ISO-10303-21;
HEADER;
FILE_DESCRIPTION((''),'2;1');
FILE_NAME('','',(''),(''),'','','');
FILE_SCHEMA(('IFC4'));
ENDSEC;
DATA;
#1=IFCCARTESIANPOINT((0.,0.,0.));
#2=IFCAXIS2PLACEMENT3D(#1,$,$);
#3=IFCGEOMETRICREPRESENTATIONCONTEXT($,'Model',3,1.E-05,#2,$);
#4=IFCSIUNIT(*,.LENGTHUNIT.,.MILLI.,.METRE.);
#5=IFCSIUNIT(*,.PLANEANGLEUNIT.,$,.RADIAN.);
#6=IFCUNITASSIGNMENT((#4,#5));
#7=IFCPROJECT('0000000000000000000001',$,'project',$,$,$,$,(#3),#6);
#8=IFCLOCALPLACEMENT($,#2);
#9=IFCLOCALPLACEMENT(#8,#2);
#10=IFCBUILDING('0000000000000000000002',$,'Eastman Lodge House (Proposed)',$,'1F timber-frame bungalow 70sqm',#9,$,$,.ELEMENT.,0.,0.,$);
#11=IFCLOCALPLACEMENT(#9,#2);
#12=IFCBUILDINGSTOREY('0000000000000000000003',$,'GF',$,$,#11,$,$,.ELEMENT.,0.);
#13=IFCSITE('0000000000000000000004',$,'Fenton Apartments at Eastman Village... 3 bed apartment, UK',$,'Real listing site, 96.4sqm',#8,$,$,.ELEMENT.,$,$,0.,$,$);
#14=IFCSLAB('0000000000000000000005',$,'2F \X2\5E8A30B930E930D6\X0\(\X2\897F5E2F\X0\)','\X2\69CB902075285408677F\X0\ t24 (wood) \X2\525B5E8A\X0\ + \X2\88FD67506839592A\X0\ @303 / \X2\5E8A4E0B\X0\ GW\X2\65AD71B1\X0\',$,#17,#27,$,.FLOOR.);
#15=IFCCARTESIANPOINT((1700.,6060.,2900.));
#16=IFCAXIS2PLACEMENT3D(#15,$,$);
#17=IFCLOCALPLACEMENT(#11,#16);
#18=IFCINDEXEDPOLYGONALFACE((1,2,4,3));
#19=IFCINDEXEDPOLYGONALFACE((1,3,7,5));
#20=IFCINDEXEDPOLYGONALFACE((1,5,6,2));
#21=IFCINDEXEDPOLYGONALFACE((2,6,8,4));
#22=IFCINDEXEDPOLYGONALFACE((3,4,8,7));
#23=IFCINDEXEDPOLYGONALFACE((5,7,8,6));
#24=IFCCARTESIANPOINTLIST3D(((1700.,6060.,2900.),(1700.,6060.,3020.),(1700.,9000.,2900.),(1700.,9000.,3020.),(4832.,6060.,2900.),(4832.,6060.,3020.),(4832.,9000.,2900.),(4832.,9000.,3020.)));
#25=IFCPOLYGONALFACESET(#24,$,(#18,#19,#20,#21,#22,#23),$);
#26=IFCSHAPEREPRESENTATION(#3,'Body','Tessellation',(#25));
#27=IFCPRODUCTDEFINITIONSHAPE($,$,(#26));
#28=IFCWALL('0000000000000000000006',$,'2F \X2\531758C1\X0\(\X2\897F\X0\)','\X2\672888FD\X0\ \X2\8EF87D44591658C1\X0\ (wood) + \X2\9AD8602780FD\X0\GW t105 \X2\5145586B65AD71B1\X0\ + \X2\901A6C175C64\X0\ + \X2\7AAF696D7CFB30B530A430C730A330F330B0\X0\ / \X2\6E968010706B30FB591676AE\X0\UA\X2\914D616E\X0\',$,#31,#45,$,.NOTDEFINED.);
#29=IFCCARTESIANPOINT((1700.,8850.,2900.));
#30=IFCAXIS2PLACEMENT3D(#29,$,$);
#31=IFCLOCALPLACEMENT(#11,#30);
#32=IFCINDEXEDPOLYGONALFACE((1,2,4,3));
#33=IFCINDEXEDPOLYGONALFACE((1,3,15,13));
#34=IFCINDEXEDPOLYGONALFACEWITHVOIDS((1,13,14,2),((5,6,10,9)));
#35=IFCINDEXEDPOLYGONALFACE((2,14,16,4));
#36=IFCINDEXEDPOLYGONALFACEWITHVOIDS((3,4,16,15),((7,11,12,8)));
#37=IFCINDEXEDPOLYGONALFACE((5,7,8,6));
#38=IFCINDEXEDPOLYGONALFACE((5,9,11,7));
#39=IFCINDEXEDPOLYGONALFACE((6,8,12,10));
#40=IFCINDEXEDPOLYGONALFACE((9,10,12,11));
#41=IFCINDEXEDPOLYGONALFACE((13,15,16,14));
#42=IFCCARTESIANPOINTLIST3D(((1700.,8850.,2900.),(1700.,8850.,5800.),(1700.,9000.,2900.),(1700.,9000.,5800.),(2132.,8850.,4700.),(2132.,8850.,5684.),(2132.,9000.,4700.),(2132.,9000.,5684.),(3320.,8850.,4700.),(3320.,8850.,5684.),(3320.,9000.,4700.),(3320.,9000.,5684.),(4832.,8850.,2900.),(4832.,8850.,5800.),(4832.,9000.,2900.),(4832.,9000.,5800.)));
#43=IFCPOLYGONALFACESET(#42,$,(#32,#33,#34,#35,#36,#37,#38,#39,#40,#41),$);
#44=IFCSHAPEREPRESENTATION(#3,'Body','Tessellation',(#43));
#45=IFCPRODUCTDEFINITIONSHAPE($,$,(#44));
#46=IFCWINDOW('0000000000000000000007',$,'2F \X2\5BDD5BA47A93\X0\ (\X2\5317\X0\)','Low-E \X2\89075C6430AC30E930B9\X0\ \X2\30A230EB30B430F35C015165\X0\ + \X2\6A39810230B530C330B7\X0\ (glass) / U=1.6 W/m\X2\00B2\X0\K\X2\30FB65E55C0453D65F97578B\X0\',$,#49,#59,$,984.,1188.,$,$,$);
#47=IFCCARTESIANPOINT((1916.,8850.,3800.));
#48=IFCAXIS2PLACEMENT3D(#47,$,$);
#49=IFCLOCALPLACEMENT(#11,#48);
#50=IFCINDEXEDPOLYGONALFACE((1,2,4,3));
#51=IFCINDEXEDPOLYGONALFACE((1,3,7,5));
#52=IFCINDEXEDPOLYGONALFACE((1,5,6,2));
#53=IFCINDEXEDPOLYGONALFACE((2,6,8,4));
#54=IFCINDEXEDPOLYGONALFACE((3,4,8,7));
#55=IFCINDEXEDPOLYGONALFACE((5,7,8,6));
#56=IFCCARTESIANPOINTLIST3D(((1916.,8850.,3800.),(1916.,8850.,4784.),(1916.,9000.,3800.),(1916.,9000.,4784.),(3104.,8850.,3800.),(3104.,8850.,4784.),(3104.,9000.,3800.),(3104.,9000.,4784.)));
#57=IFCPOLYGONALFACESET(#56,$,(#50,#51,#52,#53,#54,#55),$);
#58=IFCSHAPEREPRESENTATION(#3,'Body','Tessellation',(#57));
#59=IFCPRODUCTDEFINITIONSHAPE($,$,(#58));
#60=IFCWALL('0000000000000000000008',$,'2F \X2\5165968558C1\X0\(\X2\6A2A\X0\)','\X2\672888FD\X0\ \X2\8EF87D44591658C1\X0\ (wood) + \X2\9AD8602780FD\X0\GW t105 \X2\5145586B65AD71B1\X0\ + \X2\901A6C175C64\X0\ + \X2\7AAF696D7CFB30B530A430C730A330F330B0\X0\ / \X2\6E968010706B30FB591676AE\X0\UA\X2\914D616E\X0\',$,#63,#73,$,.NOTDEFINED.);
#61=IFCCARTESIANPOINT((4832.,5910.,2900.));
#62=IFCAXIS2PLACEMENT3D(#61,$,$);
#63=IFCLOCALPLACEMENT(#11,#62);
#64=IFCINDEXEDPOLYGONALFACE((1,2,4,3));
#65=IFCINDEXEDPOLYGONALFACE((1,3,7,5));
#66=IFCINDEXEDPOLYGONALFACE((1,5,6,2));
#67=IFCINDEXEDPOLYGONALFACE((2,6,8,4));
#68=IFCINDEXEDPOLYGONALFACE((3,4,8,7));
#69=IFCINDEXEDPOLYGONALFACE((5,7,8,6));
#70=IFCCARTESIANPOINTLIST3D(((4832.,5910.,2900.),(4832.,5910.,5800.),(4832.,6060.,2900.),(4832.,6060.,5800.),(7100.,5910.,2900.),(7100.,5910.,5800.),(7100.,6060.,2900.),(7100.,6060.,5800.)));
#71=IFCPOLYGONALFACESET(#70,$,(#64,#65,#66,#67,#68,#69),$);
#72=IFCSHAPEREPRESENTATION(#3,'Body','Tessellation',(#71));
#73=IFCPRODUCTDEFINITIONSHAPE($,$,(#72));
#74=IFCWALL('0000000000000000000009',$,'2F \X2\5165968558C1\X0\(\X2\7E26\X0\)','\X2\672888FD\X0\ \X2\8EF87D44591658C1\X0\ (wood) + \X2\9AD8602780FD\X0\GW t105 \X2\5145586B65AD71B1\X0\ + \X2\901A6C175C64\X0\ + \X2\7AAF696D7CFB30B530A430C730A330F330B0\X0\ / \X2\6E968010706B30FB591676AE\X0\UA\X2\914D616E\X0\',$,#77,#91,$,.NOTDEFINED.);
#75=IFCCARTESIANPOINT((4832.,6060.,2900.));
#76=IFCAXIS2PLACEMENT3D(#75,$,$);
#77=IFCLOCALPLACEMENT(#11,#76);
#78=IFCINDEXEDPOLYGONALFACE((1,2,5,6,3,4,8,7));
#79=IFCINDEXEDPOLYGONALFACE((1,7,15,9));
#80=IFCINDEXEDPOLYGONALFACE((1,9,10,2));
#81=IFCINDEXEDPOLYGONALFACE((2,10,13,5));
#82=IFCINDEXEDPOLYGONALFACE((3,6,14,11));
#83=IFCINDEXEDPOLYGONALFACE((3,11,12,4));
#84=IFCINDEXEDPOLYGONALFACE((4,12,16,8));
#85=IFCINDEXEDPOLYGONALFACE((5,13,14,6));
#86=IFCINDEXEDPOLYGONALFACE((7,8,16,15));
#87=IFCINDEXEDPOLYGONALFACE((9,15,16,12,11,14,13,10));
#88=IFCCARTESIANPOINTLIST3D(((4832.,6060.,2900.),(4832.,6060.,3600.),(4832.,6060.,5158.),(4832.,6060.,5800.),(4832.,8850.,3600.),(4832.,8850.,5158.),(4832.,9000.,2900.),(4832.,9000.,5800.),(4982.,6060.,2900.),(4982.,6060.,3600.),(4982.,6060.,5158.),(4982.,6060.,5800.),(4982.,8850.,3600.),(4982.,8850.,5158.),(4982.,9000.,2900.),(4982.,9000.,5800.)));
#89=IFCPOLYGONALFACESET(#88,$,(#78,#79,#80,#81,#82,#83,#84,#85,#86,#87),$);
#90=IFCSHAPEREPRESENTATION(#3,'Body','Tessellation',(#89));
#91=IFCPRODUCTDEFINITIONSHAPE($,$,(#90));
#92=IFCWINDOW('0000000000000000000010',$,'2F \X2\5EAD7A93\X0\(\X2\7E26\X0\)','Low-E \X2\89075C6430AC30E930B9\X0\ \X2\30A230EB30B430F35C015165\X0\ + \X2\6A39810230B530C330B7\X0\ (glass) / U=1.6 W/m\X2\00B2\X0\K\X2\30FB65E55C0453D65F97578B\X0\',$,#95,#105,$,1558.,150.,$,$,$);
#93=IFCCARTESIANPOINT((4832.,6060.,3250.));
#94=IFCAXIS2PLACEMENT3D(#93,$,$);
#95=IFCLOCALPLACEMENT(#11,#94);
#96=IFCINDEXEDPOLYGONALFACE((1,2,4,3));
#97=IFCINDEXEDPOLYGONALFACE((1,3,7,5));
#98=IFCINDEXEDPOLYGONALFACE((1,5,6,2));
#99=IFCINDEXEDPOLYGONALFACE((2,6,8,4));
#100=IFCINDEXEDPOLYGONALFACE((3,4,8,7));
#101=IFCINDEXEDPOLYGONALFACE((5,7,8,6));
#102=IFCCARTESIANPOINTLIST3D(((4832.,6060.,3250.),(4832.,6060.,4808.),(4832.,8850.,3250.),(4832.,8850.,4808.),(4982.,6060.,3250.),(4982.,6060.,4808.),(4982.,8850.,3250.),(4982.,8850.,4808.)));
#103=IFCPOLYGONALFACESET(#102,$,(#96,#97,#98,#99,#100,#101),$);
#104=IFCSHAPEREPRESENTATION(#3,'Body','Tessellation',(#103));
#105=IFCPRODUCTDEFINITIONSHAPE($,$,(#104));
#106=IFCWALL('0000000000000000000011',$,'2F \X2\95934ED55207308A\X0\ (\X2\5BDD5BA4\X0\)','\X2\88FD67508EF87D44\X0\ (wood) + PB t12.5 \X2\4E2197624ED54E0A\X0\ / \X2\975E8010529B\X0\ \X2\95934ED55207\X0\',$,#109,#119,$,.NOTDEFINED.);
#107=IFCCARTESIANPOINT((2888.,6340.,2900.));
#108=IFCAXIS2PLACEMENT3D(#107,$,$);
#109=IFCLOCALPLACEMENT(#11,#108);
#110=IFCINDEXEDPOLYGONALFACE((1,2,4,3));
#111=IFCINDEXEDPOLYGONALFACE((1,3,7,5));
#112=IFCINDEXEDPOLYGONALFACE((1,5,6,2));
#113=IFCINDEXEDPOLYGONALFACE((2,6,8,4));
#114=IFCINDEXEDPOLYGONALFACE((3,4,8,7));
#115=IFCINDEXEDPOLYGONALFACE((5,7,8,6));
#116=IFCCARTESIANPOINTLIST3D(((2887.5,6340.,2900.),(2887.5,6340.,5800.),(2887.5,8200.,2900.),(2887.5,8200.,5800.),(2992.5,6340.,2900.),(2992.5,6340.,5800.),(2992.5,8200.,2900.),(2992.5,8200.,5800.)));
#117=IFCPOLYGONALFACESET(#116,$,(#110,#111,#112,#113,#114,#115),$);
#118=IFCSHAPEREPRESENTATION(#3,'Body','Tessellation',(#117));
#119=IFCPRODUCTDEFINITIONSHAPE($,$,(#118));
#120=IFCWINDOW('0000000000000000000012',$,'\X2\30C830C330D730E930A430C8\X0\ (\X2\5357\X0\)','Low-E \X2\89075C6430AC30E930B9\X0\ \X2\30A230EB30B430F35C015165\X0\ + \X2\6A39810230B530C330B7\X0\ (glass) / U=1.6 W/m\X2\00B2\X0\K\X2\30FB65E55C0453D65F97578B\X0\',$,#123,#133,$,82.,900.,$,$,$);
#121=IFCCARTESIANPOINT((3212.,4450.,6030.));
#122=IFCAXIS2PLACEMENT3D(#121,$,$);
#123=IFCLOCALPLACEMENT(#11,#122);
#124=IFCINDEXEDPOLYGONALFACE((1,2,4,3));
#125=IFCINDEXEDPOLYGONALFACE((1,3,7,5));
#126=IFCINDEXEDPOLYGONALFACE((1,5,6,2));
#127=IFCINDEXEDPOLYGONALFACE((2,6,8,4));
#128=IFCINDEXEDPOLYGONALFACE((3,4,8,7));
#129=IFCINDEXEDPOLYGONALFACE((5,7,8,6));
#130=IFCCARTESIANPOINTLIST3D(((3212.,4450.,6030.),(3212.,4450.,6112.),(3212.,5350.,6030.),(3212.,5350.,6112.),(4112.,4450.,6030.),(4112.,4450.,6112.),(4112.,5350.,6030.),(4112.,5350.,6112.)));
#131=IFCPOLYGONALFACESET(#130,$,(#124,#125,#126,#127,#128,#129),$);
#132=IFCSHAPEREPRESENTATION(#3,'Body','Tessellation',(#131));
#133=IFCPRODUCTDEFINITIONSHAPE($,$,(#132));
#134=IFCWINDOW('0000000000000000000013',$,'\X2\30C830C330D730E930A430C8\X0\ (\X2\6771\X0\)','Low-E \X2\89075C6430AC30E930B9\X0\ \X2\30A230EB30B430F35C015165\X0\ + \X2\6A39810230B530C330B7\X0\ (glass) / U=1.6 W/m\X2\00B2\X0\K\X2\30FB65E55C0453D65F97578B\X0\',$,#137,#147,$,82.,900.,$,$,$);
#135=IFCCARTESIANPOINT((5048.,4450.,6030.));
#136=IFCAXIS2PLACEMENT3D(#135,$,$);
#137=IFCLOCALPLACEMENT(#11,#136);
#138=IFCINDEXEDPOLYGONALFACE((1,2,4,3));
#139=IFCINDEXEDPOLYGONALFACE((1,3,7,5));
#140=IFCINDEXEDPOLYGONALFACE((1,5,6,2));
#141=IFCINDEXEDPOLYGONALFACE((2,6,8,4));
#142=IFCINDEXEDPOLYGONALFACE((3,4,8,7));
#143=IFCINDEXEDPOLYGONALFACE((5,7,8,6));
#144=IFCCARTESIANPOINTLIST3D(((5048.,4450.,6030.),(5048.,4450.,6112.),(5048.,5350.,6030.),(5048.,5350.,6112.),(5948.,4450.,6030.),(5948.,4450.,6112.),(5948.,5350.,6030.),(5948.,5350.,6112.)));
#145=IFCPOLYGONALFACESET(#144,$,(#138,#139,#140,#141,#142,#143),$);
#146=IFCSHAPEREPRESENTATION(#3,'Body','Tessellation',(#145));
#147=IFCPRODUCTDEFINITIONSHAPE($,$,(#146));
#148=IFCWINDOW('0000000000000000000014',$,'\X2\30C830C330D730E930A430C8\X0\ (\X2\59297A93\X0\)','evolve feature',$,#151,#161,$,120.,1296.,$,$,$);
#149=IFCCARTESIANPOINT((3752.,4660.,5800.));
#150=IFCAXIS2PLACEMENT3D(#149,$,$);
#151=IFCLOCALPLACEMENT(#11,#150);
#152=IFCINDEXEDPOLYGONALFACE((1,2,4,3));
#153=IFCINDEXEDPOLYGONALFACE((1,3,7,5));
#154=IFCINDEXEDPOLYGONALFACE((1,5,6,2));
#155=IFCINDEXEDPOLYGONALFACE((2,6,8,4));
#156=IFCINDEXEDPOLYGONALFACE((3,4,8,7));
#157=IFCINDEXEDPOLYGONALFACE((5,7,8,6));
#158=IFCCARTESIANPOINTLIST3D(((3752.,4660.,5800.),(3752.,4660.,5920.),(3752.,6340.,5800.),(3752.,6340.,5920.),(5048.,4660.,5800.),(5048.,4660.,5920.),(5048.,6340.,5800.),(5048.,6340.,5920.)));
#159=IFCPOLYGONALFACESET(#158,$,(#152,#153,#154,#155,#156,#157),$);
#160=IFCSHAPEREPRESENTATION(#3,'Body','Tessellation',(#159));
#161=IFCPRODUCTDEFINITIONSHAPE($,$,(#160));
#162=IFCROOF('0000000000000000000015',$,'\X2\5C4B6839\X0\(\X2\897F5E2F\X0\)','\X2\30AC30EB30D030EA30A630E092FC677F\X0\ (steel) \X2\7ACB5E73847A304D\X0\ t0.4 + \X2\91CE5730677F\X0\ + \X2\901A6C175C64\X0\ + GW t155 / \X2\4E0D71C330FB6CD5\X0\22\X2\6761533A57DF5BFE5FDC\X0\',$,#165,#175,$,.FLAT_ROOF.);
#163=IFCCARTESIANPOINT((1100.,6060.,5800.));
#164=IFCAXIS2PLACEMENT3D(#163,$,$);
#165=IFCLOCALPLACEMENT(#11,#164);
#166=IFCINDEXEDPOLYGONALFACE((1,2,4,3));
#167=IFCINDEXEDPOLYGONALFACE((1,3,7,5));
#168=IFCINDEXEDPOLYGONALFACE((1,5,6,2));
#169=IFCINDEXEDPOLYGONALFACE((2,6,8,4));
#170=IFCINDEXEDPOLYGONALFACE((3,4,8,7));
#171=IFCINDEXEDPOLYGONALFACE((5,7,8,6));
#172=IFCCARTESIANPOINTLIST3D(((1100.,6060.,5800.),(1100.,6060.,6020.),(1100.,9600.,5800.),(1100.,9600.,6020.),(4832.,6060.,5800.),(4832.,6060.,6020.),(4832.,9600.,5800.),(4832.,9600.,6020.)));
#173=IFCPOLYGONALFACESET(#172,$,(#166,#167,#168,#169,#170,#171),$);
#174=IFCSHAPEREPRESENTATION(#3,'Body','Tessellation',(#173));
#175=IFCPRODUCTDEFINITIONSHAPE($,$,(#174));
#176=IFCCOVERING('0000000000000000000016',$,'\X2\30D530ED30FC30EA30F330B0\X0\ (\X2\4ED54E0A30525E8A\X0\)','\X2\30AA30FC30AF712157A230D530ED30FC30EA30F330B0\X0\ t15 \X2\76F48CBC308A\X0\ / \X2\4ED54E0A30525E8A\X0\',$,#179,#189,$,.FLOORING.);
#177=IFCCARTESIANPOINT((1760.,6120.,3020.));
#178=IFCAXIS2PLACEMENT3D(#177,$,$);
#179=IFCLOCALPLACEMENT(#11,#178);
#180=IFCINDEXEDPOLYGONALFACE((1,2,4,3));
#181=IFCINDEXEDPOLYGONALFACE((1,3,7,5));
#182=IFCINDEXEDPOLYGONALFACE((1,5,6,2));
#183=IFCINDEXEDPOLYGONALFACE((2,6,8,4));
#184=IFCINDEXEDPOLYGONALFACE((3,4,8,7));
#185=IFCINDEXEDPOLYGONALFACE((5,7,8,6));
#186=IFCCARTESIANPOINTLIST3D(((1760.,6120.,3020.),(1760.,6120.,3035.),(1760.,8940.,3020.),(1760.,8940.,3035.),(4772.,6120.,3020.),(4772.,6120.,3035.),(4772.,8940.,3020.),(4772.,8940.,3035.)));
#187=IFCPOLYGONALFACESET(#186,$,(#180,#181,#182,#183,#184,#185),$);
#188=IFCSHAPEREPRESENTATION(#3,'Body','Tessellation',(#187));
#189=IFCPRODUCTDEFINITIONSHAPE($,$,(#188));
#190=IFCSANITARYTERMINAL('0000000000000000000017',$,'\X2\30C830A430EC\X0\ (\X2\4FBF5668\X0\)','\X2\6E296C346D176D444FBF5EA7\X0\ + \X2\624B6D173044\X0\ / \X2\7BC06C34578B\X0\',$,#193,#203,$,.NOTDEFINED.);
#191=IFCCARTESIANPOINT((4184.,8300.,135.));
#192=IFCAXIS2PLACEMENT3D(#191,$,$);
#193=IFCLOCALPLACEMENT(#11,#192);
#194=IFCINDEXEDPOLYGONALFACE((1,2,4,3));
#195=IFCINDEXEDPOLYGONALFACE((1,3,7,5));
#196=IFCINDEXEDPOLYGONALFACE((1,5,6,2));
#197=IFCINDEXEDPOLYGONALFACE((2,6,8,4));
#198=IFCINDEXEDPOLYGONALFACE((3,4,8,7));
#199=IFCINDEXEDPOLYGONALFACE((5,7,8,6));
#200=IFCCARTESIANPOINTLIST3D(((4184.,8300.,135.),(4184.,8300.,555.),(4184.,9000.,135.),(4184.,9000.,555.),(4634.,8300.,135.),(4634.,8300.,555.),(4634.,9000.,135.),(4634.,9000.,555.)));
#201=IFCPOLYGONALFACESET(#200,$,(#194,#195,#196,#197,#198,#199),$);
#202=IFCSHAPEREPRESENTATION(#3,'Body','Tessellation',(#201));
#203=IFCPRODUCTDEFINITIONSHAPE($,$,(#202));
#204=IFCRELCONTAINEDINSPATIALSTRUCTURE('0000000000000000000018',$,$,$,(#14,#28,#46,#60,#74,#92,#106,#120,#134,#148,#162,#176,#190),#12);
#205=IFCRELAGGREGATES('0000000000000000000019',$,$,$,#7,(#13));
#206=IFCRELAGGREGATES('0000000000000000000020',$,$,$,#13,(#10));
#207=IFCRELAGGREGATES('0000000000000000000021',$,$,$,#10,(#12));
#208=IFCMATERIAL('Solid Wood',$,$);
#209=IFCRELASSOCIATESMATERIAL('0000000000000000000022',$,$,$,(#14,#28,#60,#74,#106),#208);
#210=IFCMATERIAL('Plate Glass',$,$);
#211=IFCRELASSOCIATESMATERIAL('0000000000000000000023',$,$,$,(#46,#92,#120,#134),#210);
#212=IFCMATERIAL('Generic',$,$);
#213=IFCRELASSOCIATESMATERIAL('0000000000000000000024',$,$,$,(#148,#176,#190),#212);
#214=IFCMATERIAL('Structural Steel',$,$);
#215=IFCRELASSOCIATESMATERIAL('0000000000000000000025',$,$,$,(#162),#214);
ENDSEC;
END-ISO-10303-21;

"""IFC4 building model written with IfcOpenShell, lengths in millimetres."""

from ifc_helpers import new_model, si_unit, frame, frame_2d, origin, place, context, project, spatial, rectangle, extrude, material, element, fill, save


model = new_model("IFC4")

# Units and contexts
model_context = context("Model", 3, precision=1e-05, world=origin())
ifc_project = project(units=[si_unit("LENGTHUNIT", "METRE", prefix="MILLI"), si_unit("PLANEANGLEUNIT", "RADIAN")], contexts=[model_context])

# Site, building, storey
site_placement = place(None, origin())
site = spatial("IfcSite", under=ifc_project, at=site_placement, Name="Fenton Apartments at Eastman Village... 3 bed apartment, UK", ObjectType="Real listing site, 96.4sqm", CompositionType="ELEMENT", RefElevation=0.0)
building_placement = place(site_placement, origin())
building = spatial("IfcBuilding", under=site, at=building_placement, Name="Eastman Lodge House (Proposed)", ObjectType="1F timber-frame bungalow 70sqm", CompositionType="ELEMENT", ElevationOfRefHeight=0.0, ElevationOfTerrain=0.0)
storey_placement = place(building_placement, origin())
storey = spatial("IfcBuildingStorey", under=building, at=storey_placement, Name="GF", CompositionType="ELEMENT", Elevation=0.0)

# Slab
ifc_material_1 = material(Name="Solid Wood")
slab_placement = place(storey_placement, frame((1700.0, 6060.0, 2900.0)))
element("IfcSlab", 1, at=slab_placement, inside=storey, material=ifc_material_1, Name="2F 床スラブ(西帯)", Description="構造用合板 t24 (wood) 剛床 + 製材根太 @303 / 床下 GW断熱", PredefinedType="FLOOR", context=model_context, shape_type="SweptSolid", body=[
    extrude(rectangle(XDim=3132.0, YDim=2940.0, at=frame_2d((1566.0, 1470.0))), frame((1700.0, 6060.0, 2900.0)), (0.0, 0.0, 1.0), 120.0),
])

# Wall, opening, window
wall_1_placement = place(storey_placement, frame((1700.0, 8850.0, 2900.0)))
wall_1 = element("IfcWall", 2, at=wall_1_placement, inside=storey, material=ifc_material_1, Name="2F 北壁(西)", Description="木製 軸組外壁 (wood) + 高性能GW t105 充填断熱 + 通気層 + 窯業系サイディング / 準耐火・外皮UA配慮", PredefinedType="NOTDEFINED", context=model_context, shape_type="SweptSolid", body=[
    extrude(rectangle(XDim=3132.0, YDim=150.0, at=frame_2d((1566.0, 75.0))), frame((1700.0, 8850.0, 2900.0)), (0.0, 0.0, 1.0), 2900.0),
])
opening_1_placement = place(storey_placement, frame((1916.0, 8850.0, 3800.0)))
opening_1 = element("IfcOpeningElement", 3, at=opening_1_placement, cuts=wall_1, PredefinedType="NOTDEFINED", context=model_context, shape_type="SweptSolid", body=[
    extrude(rectangle(XDim=1188.0, YDim=150.0, at=frame_2d((594.0, 75.0))), frame((1916.0, 8850.0, 3800.0)), (0.0, 0.0, 1.0), 984.0),
])
ifc_material_2 = material(Name="Plate Glass")
window_1_placement = place(storey_placement, frame((1916.0, 8850.0, 3800.0)))
window_1 = element("IfcWindow", 4, at=window_1_placement, inside=storey, material=ifc_material_2, Name="2F 寝室窓 (北)", Description="Low-E 複層ガラス アルゴン封入 + 樹脂サッシ (glass) / U=1.6 W/m²K・日射取得型", OverallHeight=984.0, OverallWidth=1188.0, context=model_context, shape_type="SweptSolid", body=[
    extrude(rectangle(XDim=1188.0, YDim=150.0, at=frame_2d((594.0, 75.0))), frame((1916.0, 8850.0, 3800.0)), (0.0, 0.0, 1.0), 984.0),
])
fill(opening_1, window_1)

# Wall
wall_2_placement = place(storey_placement, frame((4832.0, 5910.0, 2900.0)))
element("IfcWall", 5, at=wall_2_placement, inside=storey, material=ifc_material_1, Name="2F 入隅壁(横)", Description="木製 軸組外壁 (wood) + 高性能GW t105 充填断熱 + 通気層 + 窯業系サイディング / 準耐火・外皮UA配慮", PredefinedType="NOTDEFINED", context=model_context, shape_type="SweptSolid", body=[
    extrude(rectangle(XDim=2268.0, YDim=150.0, at=frame_2d((1134.0, 75.0))), frame((4832.0, 5910.0, 2900.0)), (0.0, 0.0, 1.0), 2900.0),
])

# Wall, opening, window
wall_3_placement = place(storey_placement, frame((4832.0, 6060.0, 2900.0)))
wall_3 = element("IfcWall", 6, at=wall_3_placement, inside=storey, material=ifc_material_1, Name="2F 入隅壁(縦)", Description="木製 軸組外壁 (wood) + 高性能GW t105 充填断熱 + 通気層 + 窯業系サイディング / 準耐火・外皮UA配慮", PredefinedType="NOTDEFINED", context=model_context, shape_type="SweptSolid", body=[
    extrude(rectangle(XDim=150.0, YDim=2940.0, at=frame_2d((75.0, 1470.0))), frame((4832.0, 6060.0, 2900.0)), (0.0, 0.0, 1.0), 2900.0),
])
opening_2_placement = place(storey_placement, frame((4832.0, 6060.0, 3250.0)))
opening_2 = element("IfcOpeningElement", 7, at=opening_2_placement, cuts=wall_3, PredefinedType="NOTDEFINED", context=model_context, shape_type="SweptSolid", body=[
    extrude(rectangle(XDim=150.0, YDim=2790.0, at=frame_2d((75.0, 1395.0))), frame((4832.0, 6060.0, 3250.0)), (0.0, 0.0, 1.0), 1558.0),
])
window_2_placement = place(storey_placement, frame((4832.0, 6060.0, 3250.0)))
window_2 = element("IfcWindow", 8, at=window_2_placement, inside=storey, material=ifc_material_2, Name="2F 庭窓(縦)", Description="Low-E 複層ガラス アルゴン封入 + 樹脂サッシ (glass) / U=1.6 W/m²K・日射取得型", OverallHeight=1558.0, OverallWidth=150.0, context=model_context, shape_type="SweptSolid", body=[
    extrude(rectangle(XDim=150.0, YDim=2790.0, at=frame_2d((75.0, 1395.0))), frame((4832.0, 6060.0, 3250.0)), (0.0, 0.0, 1.0), 1558.0),
])
fill(opening_2, window_2)

# Wall
wall_4_placement = place(storey_placement, frame((2888.0, 6340.0, 2900.0)))
element("IfcWall", 9, at=wall_4_placement, inside=storey, material=ifc_material_1, Name="2F 間仕切り (寝室)", Description="製材軸組 (wood) + PB t12.5 両面仕上 / 非耐力 間仕切", PredefinedType="NOTDEFINED", context=model_context, shape_type="SweptSolid", body=[
    extrude(rectangle(XDim=105.0, YDim=1860.0, at=frame_2d((52.0, 930.0))), frame((2888.0, 6340.0, 2900.0)), (0.0, 0.0, 1.0), 2900.0),
])

# Windows
window_3_placement = place(storey_placement, frame((3212.0, 4450.0, 6030.0)))
element("IfcWindow", 10, at=window_3_placement, inside=storey, material=ifc_material_2, Name="トップライト (南)", Description="Low-E 複層ガラス アルゴン封入 + 樹脂サッシ (glass) / U=1.6 W/m²K・日射取得型", OverallHeight=82.0, OverallWidth=900.0, context=model_context, shape_type="SweptSolid", body=[
    extrude(rectangle(XDim=900.0, YDim=900.0, at=frame_2d((450.0, 450.0))), frame((3212.0, 4450.0, 6030.0)), (0.0, 0.0, 1.0), 82.0),
])
window_4_placement = place(storey_placement, frame((5048.0, 4450.0, 6030.0)))
element("IfcWindow", 11, at=window_4_placement, inside=storey, material=ifc_material_2, Name="トップライト (東)", Description="Low-E 複層ガラス アルゴン封入 + 樹脂サッシ (glass) / U=1.6 W/m²K・日射取得型", OverallHeight=82.0, OverallWidth=900.0, context=model_context, shape_type="SweptSolid", body=[
    extrude(rectangle(XDim=900.0, YDim=900.0, at=frame_2d((450.0, 450.0))), frame((5048.0, 4450.0, 6030.0)), (0.0, 0.0, 1.0), 82.0),
])
ifc_material_3 = material(Name="Generic")
window_5_placement = place(storey_placement, frame((3752.0, 4660.0, 5800.0)))
element("IfcWindow", 12, at=window_5_placement, inside=storey, material=ifc_material_3, Name="トップライト (天窓)", Description="evolve feature", OverallHeight=120.0, OverallWidth=1296.0, context=model_context, shape_type="SweptSolid", body=[
    extrude(rectangle(XDim=1296.0, YDim=1680.0, at=frame_2d((648.0, 840.0))), frame((3752.0, 4660.0, 5800.0)), (0.0, 0.0, 1.0), 120.0),
])

# Roof
ifc_material_4 = material(Name="Structural Steel")
for number, where, name in (
    (13, (1100.0, 6060.0, 5800.0), "屋根(西帯)"),
):
    element("IfcRoof", number, at=place(storey_placement, frame(where)), inside=storey, material=ifc_material_4, Name=name, Description="ガルバリウム鋼板 (steel) 立平葺き t0.4 + 野地板 + 通気層 + GW t155 / 不燃・法22条区域対応", PredefinedType="FLAT_ROOF", context=model_context, shape_type="SweptSolid", body=[
        extrude(rectangle(XDim=3732.0, YDim=3540.0, at=frame_2d((1866.0, 1770.0))), frame((1100.0, 6060.0, 5800.0)), (0.0, 0.0, 1.0), 220.0),
    ])

# Covering
covering_placement = place(storey_placement, frame((1760.0, 6120.0, 3020.0)))
element("IfcCovering", 14, at=covering_placement, inside=storey, material=ifc_material_3, Name="フローリング (仕上げ床)", Description="オーク無垢フローリング t15 直貼り / 仕上げ床", PredefinedType="FLOORING", context=model_context, shape_type="SweptSolid", body=[
    extrude(rectangle(XDim=3012.0, YDim=2820.0, at=frame_2d((1506.0, 1410.0))), frame((1760.0, 6120.0, 3020.0)), (0.0, 0.0, 1.0), 15.0),
])

# Sanitary terminal
sanitary_terminal_placement = place(storey_placement, frame((4184.0, 8300.0, 135.0)))
element("IfcSanitaryTerminal", 15, at=sanitary_terminal_placement, inside=storey, material=ifc_material_3, Name="トイレ (便器)", Description="温水洗浄便座 + 手洗い / 節水型", PredefinedType="NOTDEFINED", context=model_context, shape_type="SweptSolid", body=[
    extrude(rectangle(XDim=450.0, YDim=700.0, at=frame_2d((225.0, 350.0))), frame((4184.0, 8300.0, 135.0)), (0.0, 0.0, 1.0), 420.0),
])

save(model, "model.ifc")
